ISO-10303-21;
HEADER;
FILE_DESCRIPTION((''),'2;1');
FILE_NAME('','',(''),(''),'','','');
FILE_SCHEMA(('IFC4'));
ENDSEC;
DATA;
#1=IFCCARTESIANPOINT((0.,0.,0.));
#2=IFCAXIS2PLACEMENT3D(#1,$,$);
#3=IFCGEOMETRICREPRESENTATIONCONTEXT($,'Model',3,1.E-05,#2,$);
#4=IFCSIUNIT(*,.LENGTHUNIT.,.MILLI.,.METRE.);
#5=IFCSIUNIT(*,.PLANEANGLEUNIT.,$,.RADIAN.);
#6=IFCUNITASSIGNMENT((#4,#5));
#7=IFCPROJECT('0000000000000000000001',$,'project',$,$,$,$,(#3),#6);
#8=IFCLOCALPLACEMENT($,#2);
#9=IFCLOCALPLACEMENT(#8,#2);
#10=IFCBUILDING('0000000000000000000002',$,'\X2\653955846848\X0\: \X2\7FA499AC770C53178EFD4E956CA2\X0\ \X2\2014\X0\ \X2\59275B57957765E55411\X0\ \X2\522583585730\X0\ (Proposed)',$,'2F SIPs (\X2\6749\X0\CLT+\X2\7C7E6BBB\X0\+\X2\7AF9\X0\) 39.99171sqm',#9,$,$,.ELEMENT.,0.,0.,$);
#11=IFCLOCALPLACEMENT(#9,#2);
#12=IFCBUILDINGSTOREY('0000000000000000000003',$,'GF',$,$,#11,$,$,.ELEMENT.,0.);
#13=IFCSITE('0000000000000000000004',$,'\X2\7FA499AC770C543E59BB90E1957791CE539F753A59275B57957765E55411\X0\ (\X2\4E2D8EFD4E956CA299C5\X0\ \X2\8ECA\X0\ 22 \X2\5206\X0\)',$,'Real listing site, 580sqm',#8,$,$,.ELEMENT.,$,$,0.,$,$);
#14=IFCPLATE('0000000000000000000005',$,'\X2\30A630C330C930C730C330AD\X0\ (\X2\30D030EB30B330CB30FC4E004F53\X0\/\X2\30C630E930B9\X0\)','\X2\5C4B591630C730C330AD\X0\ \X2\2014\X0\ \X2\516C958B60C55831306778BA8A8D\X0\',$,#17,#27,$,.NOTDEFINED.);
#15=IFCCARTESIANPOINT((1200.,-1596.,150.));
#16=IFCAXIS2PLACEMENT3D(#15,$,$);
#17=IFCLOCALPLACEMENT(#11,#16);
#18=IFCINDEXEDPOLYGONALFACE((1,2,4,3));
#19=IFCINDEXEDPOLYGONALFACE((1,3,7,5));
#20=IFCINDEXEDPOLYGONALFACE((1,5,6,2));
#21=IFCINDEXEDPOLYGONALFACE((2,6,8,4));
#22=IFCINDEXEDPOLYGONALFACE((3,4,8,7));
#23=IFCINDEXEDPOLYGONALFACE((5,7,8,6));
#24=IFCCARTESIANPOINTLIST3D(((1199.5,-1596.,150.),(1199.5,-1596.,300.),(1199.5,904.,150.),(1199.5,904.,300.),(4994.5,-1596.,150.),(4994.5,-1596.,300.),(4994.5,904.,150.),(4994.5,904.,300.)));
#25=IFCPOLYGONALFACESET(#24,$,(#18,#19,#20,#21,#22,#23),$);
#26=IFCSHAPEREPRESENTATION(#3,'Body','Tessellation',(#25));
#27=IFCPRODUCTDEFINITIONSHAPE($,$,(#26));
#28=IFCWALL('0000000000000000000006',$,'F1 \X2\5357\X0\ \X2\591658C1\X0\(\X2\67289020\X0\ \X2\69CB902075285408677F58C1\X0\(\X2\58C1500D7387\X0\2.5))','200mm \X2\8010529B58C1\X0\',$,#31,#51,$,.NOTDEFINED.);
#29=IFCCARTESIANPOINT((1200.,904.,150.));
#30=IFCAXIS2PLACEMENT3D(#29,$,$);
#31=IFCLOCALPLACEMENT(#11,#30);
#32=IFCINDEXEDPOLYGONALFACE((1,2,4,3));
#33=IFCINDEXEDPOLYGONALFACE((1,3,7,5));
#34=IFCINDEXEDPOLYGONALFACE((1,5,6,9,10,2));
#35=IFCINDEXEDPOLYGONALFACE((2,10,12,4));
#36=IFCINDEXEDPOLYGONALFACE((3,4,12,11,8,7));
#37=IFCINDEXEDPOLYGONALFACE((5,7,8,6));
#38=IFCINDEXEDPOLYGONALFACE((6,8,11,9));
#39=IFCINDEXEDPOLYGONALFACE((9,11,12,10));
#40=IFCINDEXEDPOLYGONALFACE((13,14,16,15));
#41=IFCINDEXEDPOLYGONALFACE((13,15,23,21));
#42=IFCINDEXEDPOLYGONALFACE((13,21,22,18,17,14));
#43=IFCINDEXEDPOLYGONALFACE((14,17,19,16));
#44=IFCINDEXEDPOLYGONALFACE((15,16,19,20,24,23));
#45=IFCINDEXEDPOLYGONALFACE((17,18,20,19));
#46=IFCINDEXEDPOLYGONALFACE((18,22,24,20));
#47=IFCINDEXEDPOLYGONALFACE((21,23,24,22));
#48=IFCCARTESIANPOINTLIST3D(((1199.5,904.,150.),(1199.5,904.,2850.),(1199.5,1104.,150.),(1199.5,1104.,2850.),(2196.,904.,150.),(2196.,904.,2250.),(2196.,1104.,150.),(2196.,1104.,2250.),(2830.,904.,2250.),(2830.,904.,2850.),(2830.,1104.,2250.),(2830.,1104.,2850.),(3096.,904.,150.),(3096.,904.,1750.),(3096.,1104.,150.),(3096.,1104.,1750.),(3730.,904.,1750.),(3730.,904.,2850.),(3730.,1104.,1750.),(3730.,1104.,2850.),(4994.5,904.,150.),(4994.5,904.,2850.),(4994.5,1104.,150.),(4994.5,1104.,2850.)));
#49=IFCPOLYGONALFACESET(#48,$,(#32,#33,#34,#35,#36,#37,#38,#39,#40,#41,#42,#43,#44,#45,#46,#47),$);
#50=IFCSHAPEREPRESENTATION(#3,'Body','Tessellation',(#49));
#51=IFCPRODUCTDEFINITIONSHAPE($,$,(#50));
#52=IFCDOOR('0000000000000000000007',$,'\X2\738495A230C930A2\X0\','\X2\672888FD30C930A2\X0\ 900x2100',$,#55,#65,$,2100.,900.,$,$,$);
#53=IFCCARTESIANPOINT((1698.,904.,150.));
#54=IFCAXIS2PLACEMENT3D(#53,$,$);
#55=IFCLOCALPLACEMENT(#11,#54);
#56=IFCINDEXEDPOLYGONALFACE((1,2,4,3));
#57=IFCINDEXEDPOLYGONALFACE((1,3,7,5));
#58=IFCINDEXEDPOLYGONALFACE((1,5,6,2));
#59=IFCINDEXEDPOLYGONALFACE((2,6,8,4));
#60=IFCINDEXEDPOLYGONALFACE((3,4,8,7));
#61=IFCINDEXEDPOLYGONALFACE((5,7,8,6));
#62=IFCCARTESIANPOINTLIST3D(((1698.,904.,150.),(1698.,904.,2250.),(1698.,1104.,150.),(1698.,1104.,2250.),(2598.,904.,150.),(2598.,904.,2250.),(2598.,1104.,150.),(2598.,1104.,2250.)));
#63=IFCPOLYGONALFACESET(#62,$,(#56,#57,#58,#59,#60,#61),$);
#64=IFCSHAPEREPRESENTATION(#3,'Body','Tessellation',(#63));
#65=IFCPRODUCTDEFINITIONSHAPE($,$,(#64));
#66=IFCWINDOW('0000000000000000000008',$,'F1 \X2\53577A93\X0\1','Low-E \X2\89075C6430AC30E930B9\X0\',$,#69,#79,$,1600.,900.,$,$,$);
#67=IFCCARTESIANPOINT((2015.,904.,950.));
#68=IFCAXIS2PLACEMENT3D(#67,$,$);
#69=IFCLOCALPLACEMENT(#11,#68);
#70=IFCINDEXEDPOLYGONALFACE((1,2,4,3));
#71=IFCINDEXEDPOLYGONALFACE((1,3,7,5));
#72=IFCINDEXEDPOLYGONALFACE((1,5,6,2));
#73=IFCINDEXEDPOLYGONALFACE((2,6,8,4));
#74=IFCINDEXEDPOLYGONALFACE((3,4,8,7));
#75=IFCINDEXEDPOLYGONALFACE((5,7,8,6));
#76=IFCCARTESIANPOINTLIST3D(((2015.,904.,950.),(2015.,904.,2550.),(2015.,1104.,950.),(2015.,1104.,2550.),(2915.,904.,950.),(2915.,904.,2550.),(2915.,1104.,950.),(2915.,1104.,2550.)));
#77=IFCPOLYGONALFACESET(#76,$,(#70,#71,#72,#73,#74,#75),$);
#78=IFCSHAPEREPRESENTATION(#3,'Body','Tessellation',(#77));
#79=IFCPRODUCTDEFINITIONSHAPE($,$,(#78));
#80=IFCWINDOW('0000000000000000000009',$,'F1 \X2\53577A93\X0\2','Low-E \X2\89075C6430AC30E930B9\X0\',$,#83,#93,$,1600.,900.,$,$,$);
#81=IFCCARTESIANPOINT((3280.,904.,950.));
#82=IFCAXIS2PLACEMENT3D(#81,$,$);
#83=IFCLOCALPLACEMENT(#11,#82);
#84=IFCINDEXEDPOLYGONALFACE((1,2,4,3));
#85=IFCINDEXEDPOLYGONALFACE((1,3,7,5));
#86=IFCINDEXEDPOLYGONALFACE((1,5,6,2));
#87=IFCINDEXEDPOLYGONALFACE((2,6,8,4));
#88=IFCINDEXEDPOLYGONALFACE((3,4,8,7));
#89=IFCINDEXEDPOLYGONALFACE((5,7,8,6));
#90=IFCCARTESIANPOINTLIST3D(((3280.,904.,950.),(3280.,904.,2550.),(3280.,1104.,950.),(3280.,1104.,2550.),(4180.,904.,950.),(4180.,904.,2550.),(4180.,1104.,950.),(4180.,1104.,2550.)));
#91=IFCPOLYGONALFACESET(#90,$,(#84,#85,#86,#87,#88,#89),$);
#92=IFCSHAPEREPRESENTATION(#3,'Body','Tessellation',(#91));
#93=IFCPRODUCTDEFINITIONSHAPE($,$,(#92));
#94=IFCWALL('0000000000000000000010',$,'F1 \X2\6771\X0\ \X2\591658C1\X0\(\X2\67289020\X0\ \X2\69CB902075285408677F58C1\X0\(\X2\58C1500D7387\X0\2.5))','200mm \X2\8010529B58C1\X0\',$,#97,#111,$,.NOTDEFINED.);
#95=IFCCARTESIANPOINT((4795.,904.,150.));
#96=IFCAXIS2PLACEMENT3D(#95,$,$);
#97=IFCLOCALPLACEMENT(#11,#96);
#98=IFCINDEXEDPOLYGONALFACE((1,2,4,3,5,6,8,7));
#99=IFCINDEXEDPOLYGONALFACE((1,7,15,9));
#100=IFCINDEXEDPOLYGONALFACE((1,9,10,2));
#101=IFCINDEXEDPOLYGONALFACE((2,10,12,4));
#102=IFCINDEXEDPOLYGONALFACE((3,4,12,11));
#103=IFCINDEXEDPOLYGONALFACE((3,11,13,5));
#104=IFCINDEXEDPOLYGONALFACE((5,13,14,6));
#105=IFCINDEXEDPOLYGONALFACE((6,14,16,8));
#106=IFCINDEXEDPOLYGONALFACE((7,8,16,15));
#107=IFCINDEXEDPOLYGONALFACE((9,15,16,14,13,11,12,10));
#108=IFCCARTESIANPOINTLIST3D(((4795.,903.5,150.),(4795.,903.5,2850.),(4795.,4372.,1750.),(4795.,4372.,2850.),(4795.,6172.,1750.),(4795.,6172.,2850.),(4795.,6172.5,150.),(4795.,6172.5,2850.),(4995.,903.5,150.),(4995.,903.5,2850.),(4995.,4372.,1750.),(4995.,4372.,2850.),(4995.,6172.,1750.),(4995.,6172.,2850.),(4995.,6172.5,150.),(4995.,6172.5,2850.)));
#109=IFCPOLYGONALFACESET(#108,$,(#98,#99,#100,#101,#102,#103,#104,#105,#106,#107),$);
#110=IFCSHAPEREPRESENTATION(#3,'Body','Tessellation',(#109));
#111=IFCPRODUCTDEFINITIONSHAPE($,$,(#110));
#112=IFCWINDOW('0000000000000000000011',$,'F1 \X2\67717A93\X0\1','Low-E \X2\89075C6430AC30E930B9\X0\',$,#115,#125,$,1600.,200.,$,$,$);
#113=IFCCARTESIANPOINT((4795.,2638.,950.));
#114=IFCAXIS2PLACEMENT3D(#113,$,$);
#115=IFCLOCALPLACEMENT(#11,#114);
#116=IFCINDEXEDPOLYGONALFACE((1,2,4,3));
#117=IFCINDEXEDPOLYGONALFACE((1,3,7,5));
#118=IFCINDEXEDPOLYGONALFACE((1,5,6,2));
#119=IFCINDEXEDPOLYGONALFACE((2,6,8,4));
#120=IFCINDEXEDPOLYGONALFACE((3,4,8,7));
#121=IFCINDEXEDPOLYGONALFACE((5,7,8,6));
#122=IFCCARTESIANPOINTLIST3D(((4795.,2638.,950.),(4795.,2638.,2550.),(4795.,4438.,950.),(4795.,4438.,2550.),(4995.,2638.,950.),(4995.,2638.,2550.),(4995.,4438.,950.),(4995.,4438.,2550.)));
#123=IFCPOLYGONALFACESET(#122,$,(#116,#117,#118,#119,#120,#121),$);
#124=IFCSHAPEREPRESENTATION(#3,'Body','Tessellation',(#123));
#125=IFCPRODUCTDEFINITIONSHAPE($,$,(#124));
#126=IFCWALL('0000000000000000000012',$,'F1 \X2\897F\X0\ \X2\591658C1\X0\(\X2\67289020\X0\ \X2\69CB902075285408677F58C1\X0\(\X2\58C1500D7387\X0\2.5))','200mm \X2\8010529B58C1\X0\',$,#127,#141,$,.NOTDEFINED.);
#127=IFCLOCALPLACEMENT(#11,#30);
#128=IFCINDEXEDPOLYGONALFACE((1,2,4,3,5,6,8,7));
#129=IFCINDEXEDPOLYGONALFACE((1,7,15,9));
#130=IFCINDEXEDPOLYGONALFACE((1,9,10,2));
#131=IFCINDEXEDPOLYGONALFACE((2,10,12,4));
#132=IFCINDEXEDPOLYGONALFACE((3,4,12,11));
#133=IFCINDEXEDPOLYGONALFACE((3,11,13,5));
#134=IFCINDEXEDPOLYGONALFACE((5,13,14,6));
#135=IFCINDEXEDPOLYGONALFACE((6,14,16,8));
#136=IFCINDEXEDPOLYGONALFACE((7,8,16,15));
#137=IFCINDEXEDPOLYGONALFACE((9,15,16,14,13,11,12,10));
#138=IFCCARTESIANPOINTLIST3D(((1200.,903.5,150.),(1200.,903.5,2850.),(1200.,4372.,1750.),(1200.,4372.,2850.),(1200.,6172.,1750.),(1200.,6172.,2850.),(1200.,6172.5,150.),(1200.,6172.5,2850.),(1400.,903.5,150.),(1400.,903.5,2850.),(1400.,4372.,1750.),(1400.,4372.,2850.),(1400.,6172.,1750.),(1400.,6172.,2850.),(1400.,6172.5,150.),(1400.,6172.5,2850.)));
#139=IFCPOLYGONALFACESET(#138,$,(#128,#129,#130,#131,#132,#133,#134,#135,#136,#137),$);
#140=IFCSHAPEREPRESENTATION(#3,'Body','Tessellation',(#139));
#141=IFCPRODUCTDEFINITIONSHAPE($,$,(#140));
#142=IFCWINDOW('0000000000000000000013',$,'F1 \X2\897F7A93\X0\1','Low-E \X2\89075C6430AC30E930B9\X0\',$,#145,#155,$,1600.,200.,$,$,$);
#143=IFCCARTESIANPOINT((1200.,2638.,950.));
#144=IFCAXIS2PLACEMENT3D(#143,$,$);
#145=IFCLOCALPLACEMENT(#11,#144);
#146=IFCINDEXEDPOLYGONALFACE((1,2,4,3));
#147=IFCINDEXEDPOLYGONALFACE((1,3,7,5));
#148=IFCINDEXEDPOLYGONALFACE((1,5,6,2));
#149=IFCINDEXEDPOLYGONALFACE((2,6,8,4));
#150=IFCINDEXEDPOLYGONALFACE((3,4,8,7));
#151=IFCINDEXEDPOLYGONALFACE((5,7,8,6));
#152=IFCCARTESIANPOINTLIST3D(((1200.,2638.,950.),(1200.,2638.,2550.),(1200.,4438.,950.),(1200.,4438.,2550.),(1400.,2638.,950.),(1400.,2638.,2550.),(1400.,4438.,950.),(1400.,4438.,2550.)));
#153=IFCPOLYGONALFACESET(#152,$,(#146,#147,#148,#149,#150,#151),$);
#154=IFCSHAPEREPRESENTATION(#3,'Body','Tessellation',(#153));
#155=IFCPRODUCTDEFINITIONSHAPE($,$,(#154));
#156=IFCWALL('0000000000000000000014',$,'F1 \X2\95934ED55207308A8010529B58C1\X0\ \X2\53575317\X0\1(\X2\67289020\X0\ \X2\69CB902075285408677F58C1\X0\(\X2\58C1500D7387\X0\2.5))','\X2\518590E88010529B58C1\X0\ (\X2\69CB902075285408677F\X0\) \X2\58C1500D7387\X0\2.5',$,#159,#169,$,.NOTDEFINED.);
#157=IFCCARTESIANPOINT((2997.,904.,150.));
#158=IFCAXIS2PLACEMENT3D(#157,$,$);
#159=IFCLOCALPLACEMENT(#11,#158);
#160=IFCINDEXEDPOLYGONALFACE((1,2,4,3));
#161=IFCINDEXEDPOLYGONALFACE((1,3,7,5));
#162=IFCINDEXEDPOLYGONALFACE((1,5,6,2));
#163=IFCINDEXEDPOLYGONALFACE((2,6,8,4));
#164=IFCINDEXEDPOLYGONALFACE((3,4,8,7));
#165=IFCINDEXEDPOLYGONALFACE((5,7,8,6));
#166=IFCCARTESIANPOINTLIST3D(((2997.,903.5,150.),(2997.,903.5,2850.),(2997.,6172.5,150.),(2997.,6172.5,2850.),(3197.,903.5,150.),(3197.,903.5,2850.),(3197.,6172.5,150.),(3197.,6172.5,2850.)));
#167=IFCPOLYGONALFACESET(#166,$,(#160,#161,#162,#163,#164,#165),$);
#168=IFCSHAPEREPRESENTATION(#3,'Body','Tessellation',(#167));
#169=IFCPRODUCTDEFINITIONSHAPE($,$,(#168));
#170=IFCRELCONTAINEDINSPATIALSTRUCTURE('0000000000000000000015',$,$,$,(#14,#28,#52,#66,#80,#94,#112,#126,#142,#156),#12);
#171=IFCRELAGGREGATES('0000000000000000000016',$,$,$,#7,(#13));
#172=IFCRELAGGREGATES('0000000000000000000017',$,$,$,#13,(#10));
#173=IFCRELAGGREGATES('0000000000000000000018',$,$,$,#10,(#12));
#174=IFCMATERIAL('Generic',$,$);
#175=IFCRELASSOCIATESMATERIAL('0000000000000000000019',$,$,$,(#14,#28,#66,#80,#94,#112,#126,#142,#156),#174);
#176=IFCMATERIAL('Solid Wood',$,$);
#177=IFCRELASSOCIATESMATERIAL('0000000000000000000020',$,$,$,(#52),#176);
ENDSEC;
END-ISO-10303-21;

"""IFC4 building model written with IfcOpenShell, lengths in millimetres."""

from ifc_helpers import new_model, si_unit, frame, frame_2d, origin, place, context, project, spatial, rectangle, extrude, material, element, fill, save


model = new_model("IFC4")

# Units and contexts
model_context = context("Model", 3, precision=1e-05, world=origin())
ifc_project = project(units=[si_unit("LENGTHUNIT", "METRE", prefix="MILLI"), si_unit("PLANEANGLEUNIT", "RADIAN")], contexts=[model_context])

# Site, building, storey
site_placement = place(None, origin())
site = spatial("IfcSite", under=ifc_project, at=site_placement, Name="群馬県吾妻郡長野原町大字長日向 (中軽井沢駅 車 22 分)", ObjectType="Real listing site, 580sqm", CompositionType="ELEMENT", RefElevation=0.0)
building_placement = place(site_placement, origin())
building = spatial("IfcBuilding", under=site, at=building_placement, Name="改善案: 群馬県北軽井沢 — 大字長日向 別荘地 (Proposed)", ObjectType="2F SIPs (杉CLT+籾殻+竹) 39.99171sqm", CompositionType="ELEMENT", ElevationOfRefHeight=0.0, ElevationOfTerrain=0.0)
storey_placement = place(building_placement, origin())
storey = spatial("IfcBuildingStorey", under=building, at=storey_placement, Name="GF", CompositionType="ELEMENT", Elevation=0.0)

# Shared definitions
ifc_material_1 = material(Name="Generic")

# Plate
plate_placement = place(storey_placement, frame((1200.0, -1596.0, 150.0)))
element("IfcPlate", 1, at=plate_placement, inside=storey, material=ifc_material_1, Name="ウッドデッキ (バルコニー一体/テラス)", Description="屋外デッキ — 公開情報で確認", PredefinedType="NOTDEFINED", context=model_context, shape_type="SweptSolid", body=[
    extrude(rectangle(XDim=3795.0, YDim=2500.0, at=frame_2d((1897.0, 1250.0))), frame((1200.0, -1596.0, 150.0)), (0.0, 0.0, 1.0), 150.0),
])

# Wall, openings, door, windows
wall_1_placement = place(storey_placement, frame((1200.0, 904.0, 150.0)))
wall_1 = element("IfcWall", 2, at=wall_1_placement, inside=storey, material=ifc_material_1, Name="F1 南 外壁(木造 構造用合板壁(壁倍率2.5))", Description="200mm 耐力壁", PredefinedType="NOTDEFINED", context=model_context, shape_type="SweptSolid", body=[
    extrude(rectangle(XDim=3795.0, YDim=200.0, at=frame_2d((1897.0, 100.0))), frame((1200.0, 904.0, 150.0)), (0.0, 0.0, 1.0), 2700.0),
])
opening_1_placement = place(storey_placement, frame((1698.0, 904.0, 150.0)))
opening_1 = element("IfcOpeningElement", 3, at=opening_1_placement, cuts=wall_1, PredefinedType="NOTDEFINED", context=model_context, shape_type="SweptSolid", body=[
    extrude(rectangle(XDim=900.0, YDim=200.0, at=frame_2d((450.0, 100.0))), frame((1698.0, 904.0, 150.0)), (0.0, 0.0, 1.0), 2100.0),
])
opening_2_placement = place(storey_placement, frame((2015.0, 904.0, 950.0)))
opening_2 = element("IfcOpeningElement", 4, at=opening_2_placement, cuts=wall_1, PredefinedType="NOTDEFINED", context=model_context, shape_type="SweptSolid", body=[
    extrude(rectangle(XDim=900.0, YDim=200.0, at=frame_2d((450.0, 100.0))), frame((2015.0, 904.0, 950.0)), (0.0, 0.0, 1.0), 1600.0),
])
opening_3_placement = place(storey_placement, frame((3280.0, 904.0, 950.0)))
opening_3 = element("IfcOpeningElement", 5, at=opening_3_placement, cuts=wall_1, PredefinedType="NOTDEFINED", context=model_context, shape_type="SweptSolid", body=[
    extrude(rectangle(XDim=900.0, YDim=200.0, at=frame_2d((450.0, 100.0))), frame((3280.0, 904.0, 950.0)), (0.0, 0.0, 1.0), 1600.0),
])
ifc_material_2 = material(Name="Solid Wood")
door_placement = place(storey_placement, frame((1698.0, 904.0, 150.0)))
door = element("IfcDoor", 6, at=door_placement, inside=storey, material=ifc_material_2, Name="玄関ドア", Description="木製ドア 900x2100", OverallHeight=2100.0, OverallWidth=900.0, context=model_context, shape_type="SweptSolid", body=[
    extrude(rectangle(XDim=900.0, YDim=200.0, at=frame_2d((450.0, 100.0))), frame((1698.0, 904.0, 150.0)), (0.0, 0.0, 1.0), 2100.0),
])
fill(opening_1, door)
window_1_placement = place(storey_placement, frame((2015.0, 904.0, 950.0)))
window_1 = element("IfcWindow", 7, at=window_1_placement, inside=storey, material=ifc_material_1, Name="F1 南窓1", Description="Low-E 複層ガラス", OverallHeight=1600.0, OverallWidth=900.0, context=model_context, shape_type="SweptSolid", body=[
    extrude(rectangle(XDim=900.0, YDim=200.0, at=frame_2d((450.0, 100.0))), frame((2015.0, 904.0, 950.0)), (0.0, 0.0, 1.0), 1600.0),
])
fill(opening_2, window_1)
window_2_placement = place(storey_placement, frame((3280.0, 904.0, 950.0)))
window_2 = element("IfcWindow", 8, at=window_2_placement, inside=storey, material=ifc_material_1, Name="F1 南窓2", Description="Low-E 複層ガラス", OverallHeight=1600.0, OverallWidth=900.0, context=model_context, shape_type="SweptSolid", body=[
    extrude(rectangle(XDim=900.0, YDim=200.0, at=frame_2d((450.0, 100.0))), frame((3280.0, 904.0, 950.0)), (0.0, 0.0, 1.0), 1600.0),
])
fill(opening_3, window_2)

# Walls, openings, windows
wall_2_placement = place(storey_placement, frame((4795.0, 904.0, 150.0)))
wall_2 = element("IfcWall", 9, at=wall_2_placement, inside=storey, material=ifc_material_1, Name="F1 東 外壁(木造 構造用合板壁(壁倍率2.5))", Description="200mm 耐力壁", PredefinedType="NOTDEFINED", context=model_context, shape_type="SweptSolid", body=[
    extrude(rectangle(XDim=200.0, YDim=5269.0, at=frame_2d((100.0, 2634.0))), frame((4795.0, 904.0, 150.0)), (0.0, 0.0, 1.0), 2700.0),
])
opening_4_placement = place(storey_placement, frame((4795.0, 2638.0, 950.0)))
opening_4 = element("IfcOpeningElement", 10, at=opening_4_placement, cuts=wall_2, PredefinedType="NOTDEFINED", context=model_context, shape_type="SweptSolid", body=[
    extrude(rectangle(XDim=200.0, YDim=1800.0, at=frame_2d((100.0, 900.0))), frame((4795.0, 2638.0, 950.0)), (0.0, 0.0, 1.0), 1600.0),
])
window_3_placement = place(storey_placement, frame((4795.0, 2638.0, 950.0)))
window_3 = element("IfcWindow", 11, at=window_3_placement, inside=storey, material=ifc_material_1, Name="F1 東窓1", Description="Low-E 複層ガラス", OverallHeight=1600.0, OverallWidth=200.0, context=model_context, shape_type="SweptSolid", body=[
    extrude(rectangle(XDim=200.0, YDim=1800.0, at=frame_2d((100.0, 900.0))), frame((4795.0, 2638.0, 950.0)), (0.0, 0.0, 1.0), 1600.0),
])
fill(opening_4, window_3)
wall_3_placement = place(storey_placement, frame((1200.0, 904.0, 150.0)))
wall_3 = element("IfcWall", 12, at=wall_3_placement, inside=storey, material=ifc_material_1, Name="F1 西 外壁(木造 構造用合板壁(壁倍率2.5))", Description="200mm 耐力壁", PredefinedType="NOTDEFINED", context=model_context, shape_type="SweptSolid", body=[
    extrude(rectangle(XDim=200.0, YDim=5269.0, at=frame_2d((100.0, 2634.0))), frame((1200.0, 904.0, 150.0)), (0.0, 0.0, 1.0), 2700.0),
])
opening_5_placement = place(storey_placement, frame((1200.0, 2638.0, 950.0)))
opening_5 = element("IfcOpeningElement", 13, at=opening_5_placement, cuts=wall_3, PredefinedType="NOTDEFINED", context=model_context, shape_type="SweptSolid", body=[
    extrude(rectangle(XDim=200.0, YDim=1800.0, at=frame_2d((100.0, 900.0))), frame((1200.0, 2638.0, 950.0)), (0.0, 0.0, 1.0), 1600.0),
])
window_4_placement = place(storey_placement, frame((1200.0, 2638.0, 950.0)))
window_4 = element("IfcWindow", 14, at=window_4_placement, inside=storey, material=ifc_material_1, Name="F1 西窓1", Description="Low-E 複層ガラス", OverallHeight=1600.0, OverallWidth=200.0, context=model_context, shape_type="SweptSolid", body=[
    extrude(rectangle(XDim=200.0, YDim=1800.0, at=frame_2d((100.0, 900.0))), frame((1200.0, 2638.0, 950.0)), (0.0, 0.0, 1.0), 1600.0),
])
fill(opening_5, window_4)

# Wall
wall_4_placement = place(storey_placement, frame((2997.0, 904.0, 150.0)))
element("IfcWall", 15, at=wall_4_placement, inside=storey, material=ifc_material_1, Name="F1 間仕切り耐力壁 南北1(木造 構造用合板壁(壁倍率2.5))", Description="内部耐力壁 (構造用合板) 壁倍率2.5", PredefinedType="NOTDEFINED", context=model_context, shape_type="SweptSolid", body=[
    extrude(rectangle(XDim=200.0, YDim=5269.0, at=frame_2d((100.0, 2634.0))), frame((2997.0, 904.0, 150.0)), (0.0, 0.0, 1.0), 2700.0),
])

save(model, "model.ifc")
